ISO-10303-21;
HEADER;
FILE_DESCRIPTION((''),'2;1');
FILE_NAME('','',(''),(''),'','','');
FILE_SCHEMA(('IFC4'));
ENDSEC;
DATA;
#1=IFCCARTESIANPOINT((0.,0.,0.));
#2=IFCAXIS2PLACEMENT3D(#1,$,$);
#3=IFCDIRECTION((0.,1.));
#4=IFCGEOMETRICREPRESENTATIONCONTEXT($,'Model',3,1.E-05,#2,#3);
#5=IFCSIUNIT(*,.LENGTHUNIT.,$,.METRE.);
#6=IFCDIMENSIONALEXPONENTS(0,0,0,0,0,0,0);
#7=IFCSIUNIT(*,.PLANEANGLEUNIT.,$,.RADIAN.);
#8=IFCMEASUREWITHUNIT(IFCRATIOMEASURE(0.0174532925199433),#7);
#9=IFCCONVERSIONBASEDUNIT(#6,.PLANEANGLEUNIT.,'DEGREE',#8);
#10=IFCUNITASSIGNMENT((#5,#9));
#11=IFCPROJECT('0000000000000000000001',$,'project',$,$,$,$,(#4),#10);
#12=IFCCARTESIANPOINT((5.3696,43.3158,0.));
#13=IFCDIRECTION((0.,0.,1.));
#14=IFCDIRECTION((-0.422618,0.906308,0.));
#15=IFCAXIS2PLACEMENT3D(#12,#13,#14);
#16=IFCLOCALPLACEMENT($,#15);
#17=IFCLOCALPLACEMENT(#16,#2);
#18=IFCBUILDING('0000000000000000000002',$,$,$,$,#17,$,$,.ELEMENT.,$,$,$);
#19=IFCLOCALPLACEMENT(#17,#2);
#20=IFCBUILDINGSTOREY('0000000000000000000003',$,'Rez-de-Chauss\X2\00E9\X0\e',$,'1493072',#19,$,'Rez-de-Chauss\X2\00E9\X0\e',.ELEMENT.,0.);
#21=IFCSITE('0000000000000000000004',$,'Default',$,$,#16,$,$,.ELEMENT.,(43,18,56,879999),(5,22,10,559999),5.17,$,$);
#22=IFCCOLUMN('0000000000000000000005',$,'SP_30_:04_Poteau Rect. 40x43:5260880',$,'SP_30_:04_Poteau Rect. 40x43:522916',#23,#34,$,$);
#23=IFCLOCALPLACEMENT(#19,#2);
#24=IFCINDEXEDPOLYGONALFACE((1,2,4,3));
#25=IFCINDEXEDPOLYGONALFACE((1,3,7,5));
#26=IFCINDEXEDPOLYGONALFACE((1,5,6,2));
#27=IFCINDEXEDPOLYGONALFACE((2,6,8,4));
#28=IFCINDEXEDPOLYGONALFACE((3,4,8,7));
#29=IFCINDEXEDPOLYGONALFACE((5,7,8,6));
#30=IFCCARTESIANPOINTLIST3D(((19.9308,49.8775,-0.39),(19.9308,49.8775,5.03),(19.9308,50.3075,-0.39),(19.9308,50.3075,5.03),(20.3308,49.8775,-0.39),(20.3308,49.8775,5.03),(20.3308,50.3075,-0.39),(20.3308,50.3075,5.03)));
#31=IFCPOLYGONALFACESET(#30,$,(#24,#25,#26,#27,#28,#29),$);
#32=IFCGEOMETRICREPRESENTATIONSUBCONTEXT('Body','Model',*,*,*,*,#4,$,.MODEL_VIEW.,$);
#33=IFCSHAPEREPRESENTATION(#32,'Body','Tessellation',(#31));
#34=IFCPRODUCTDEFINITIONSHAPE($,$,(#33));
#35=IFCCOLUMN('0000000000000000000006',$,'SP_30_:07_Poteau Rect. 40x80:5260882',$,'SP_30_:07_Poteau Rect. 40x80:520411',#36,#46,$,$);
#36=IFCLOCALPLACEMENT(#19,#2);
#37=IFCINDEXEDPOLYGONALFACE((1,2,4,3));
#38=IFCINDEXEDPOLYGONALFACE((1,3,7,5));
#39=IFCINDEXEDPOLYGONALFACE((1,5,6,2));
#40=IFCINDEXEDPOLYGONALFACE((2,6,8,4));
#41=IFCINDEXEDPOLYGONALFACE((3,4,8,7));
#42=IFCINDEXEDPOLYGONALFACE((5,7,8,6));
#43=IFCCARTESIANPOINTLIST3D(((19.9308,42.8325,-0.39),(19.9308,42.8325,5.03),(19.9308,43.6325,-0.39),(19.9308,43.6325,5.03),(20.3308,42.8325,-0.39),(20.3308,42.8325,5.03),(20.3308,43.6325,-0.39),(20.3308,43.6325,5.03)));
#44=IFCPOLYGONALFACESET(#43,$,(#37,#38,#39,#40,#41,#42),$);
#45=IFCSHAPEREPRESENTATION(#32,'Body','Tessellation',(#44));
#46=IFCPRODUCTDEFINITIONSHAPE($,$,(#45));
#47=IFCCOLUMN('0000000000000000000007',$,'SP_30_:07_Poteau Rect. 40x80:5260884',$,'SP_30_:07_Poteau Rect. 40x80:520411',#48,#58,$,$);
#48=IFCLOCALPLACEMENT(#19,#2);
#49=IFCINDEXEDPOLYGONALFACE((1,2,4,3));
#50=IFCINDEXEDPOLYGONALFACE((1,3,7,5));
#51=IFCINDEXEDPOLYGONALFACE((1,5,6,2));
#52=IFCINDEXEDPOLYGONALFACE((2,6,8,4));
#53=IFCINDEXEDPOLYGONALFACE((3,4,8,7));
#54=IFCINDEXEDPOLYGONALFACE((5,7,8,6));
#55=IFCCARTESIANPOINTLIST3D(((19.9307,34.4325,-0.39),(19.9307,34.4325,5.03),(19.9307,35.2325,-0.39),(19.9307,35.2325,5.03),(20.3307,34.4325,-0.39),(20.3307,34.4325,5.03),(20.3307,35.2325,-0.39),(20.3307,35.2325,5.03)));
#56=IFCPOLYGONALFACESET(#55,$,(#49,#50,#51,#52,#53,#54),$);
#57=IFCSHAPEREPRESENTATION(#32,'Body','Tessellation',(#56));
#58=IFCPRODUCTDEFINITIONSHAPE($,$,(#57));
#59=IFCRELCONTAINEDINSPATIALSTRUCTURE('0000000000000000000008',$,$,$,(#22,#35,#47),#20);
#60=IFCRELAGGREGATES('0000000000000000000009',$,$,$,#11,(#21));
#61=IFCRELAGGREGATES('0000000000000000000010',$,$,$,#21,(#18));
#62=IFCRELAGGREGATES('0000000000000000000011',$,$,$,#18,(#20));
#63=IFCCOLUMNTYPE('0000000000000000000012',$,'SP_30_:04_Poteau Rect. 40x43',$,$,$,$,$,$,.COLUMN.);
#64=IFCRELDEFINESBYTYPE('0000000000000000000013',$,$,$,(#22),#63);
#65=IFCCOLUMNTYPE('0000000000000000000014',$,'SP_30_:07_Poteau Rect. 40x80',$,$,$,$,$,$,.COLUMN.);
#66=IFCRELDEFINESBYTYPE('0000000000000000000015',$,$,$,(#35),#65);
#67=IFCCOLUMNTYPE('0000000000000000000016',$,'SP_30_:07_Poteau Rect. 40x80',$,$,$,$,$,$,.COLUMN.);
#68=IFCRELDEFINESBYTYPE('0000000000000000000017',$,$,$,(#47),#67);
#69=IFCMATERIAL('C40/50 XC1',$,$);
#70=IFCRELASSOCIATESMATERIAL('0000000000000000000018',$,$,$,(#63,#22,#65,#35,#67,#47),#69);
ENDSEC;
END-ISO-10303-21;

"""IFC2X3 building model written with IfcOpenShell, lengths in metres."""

from ifc_helpers import new_model, entity, si_unit, converted_unit, direction, frame, frame_2d, origin, place, context, subcontext, project, spatial, rectangle, extrude, source, transform, mapped, material, type_object, type_shapes, element, save


model = new_model("IFC2X3")

# Units and contexts
model_context = context("Model", 3, precision=1e-05, world=origin(), true_north=direction((0.0, 1.0)))
body_context = subcontext(model_context, "Body", "Model", "MODEL_VIEW")
ifc_project = project(units=[si_unit("LENGTHUNIT", "METRE"), converted_unit("PLANEANGLEUNIT", "DEGREE", entity("IfcRatioMeasure", 0.0174532925199433), si_unit("PLANEANGLEUNIT", "RADIAN"), dimensions=[0, 0, 0, 0, 0, 0, 0])], contexts=[model_context])

# Site, building, storey
site_placement = place(None, frame((5.3696, 43.3158, 0.0), z_axis=(0.0, 0.0, 1.0), x_axis=(-0.422618, 0.906308, 0.0)))
site = spatial("IfcSite", under=ifc_project, at=site_placement, Name="Default", CompositionType="ELEMENT", RefLatitude=(43, 18, 56, 879999), RefLongitude=(5, 22, 10, 559999), RefElevation=5.17)
building_placement = place(site_placement, origin())
building = spatial("IfcBuilding", under=site, at=building_placement, CompositionType="ELEMENT")
storey_placement = place(building_placement, origin())
storey = spatial("IfcBuildingStorey", under=building, at=storey_placement, Name="Rez-de-Chaussée", ObjectType="1493072", LongName="Rez-de-Chaussée", CompositionType="ELEMENT", Elevation=0.0)

# Columns
ifc_material_1 = material(Name="C40/50 XC1")
column_type_1 = type_object("IfcColumnType", Name="SP_30_:04_Poteau Rect. 40x43", PredefinedType="COLUMN", material=ifc_material_1)
shared_shape_1 = source(origin(), body_context, "Body", "SweptSolid", [
    extrude(rectangle(XDim=0.43, YDim=0.4, at=frame_2d((0.0, 0.0), x_axis=(1.0, 0.0))), frame((20.1308, 50.0925, -0.39), z_axis=(0.0, 0.0, 1.0), x_axis=(0.0, 1.0, 0.0)), (0.0, 0.0, 1.0), 5.42),
])
type_shapes(column_type_1, [shared_shape_1])
column_1_placement = place(storey_placement, origin())
element("IfcColumn", 1, at=column_1_placement, inside=storey, type_object=column_type_1, material=ifc_material_1, Name="SP_30_:04_Poteau Rect. 40x43:5260880", ObjectType="SP_30_:04_Poteau Rect. 40x43:522916", context=body_context, shape_type="MappedRepresentation", body=[
    mapped(shared_shape_1, transform((0.0, 0.0, 0.0), scale=1.0)),
])
column_type_2 = type_object("IfcColumnType", Name="SP_30_:07_Poteau Rect. 40x80", PredefinedType="COLUMN", material=ifc_material_1)
shared_shape_2 = source(origin(), body_context, "Body", "SweptSolid", [
    extrude(rectangle(XDim=0.8, YDim=0.4, at=frame_2d((0.0, 0.0), x_axis=(1.0, 0.0))), frame((20.1308, 43.2325, -0.39), z_axis=(0.0, 0.0, 1.0), x_axis=(0.0, 1.0, 0.0)), (0.0, 0.0, 1.0), 5.42),
])
type_shapes(column_type_2, [shared_shape_2])
column_2_placement = place(storey_placement, origin())
element("IfcColumn", 2, at=column_2_placement, inside=storey, type_object=column_type_2, material=ifc_material_1, Name="SP_30_:07_Poteau Rect. 40x80:5260882", ObjectType="SP_30_:07_Poteau Rect. 40x80:520411", context=body_context, shape_type="MappedRepresentation", body=[
    mapped(shared_shape_2, transform((0.0, 0.0, 0.0), scale=1.0)),
])
column_type_3 = type_object("IfcColumnType", Name="SP_30_:07_Poteau Rect. 40x80", PredefinedType="COLUMN", material=ifc_material_1)
shared_shape_3 = source(origin(), body_context, "Body", "SweptSolid", [
    extrude(rectangle(XDim=0.8, YDim=0.4, at=frame_2d((0.0, 0.0), x_axis=(1.0, 0.0))), frame((20.1307, 34.8325, -0.39), z_axis=(0.0, 0.0, 1.0), x_axis=(0.0, 1.0, 0.0)), (0.0, 0.0, 1.0), 5.42),
])
type_shapes(column_type_3, [shared_shape_3])
column_3_placement = place(storey_placement, origin())
element("IfcColumn", 3, at=column_3_placement, inside=storey, type_object=column_type_3, material=ifc_material_1, Name="SP_30_:07_Poteau Rect. 40x80:5260884", ObjectType="SP_30_:07_Poteau Rect. 40x80:520411", context=body_context, shape_type="MappedRepresentation", body=[
    mapped(shared_shape_3, transform((0.0, 0.0, 0.0), scale=1.0)),
])

save(model, "model.ifc")
